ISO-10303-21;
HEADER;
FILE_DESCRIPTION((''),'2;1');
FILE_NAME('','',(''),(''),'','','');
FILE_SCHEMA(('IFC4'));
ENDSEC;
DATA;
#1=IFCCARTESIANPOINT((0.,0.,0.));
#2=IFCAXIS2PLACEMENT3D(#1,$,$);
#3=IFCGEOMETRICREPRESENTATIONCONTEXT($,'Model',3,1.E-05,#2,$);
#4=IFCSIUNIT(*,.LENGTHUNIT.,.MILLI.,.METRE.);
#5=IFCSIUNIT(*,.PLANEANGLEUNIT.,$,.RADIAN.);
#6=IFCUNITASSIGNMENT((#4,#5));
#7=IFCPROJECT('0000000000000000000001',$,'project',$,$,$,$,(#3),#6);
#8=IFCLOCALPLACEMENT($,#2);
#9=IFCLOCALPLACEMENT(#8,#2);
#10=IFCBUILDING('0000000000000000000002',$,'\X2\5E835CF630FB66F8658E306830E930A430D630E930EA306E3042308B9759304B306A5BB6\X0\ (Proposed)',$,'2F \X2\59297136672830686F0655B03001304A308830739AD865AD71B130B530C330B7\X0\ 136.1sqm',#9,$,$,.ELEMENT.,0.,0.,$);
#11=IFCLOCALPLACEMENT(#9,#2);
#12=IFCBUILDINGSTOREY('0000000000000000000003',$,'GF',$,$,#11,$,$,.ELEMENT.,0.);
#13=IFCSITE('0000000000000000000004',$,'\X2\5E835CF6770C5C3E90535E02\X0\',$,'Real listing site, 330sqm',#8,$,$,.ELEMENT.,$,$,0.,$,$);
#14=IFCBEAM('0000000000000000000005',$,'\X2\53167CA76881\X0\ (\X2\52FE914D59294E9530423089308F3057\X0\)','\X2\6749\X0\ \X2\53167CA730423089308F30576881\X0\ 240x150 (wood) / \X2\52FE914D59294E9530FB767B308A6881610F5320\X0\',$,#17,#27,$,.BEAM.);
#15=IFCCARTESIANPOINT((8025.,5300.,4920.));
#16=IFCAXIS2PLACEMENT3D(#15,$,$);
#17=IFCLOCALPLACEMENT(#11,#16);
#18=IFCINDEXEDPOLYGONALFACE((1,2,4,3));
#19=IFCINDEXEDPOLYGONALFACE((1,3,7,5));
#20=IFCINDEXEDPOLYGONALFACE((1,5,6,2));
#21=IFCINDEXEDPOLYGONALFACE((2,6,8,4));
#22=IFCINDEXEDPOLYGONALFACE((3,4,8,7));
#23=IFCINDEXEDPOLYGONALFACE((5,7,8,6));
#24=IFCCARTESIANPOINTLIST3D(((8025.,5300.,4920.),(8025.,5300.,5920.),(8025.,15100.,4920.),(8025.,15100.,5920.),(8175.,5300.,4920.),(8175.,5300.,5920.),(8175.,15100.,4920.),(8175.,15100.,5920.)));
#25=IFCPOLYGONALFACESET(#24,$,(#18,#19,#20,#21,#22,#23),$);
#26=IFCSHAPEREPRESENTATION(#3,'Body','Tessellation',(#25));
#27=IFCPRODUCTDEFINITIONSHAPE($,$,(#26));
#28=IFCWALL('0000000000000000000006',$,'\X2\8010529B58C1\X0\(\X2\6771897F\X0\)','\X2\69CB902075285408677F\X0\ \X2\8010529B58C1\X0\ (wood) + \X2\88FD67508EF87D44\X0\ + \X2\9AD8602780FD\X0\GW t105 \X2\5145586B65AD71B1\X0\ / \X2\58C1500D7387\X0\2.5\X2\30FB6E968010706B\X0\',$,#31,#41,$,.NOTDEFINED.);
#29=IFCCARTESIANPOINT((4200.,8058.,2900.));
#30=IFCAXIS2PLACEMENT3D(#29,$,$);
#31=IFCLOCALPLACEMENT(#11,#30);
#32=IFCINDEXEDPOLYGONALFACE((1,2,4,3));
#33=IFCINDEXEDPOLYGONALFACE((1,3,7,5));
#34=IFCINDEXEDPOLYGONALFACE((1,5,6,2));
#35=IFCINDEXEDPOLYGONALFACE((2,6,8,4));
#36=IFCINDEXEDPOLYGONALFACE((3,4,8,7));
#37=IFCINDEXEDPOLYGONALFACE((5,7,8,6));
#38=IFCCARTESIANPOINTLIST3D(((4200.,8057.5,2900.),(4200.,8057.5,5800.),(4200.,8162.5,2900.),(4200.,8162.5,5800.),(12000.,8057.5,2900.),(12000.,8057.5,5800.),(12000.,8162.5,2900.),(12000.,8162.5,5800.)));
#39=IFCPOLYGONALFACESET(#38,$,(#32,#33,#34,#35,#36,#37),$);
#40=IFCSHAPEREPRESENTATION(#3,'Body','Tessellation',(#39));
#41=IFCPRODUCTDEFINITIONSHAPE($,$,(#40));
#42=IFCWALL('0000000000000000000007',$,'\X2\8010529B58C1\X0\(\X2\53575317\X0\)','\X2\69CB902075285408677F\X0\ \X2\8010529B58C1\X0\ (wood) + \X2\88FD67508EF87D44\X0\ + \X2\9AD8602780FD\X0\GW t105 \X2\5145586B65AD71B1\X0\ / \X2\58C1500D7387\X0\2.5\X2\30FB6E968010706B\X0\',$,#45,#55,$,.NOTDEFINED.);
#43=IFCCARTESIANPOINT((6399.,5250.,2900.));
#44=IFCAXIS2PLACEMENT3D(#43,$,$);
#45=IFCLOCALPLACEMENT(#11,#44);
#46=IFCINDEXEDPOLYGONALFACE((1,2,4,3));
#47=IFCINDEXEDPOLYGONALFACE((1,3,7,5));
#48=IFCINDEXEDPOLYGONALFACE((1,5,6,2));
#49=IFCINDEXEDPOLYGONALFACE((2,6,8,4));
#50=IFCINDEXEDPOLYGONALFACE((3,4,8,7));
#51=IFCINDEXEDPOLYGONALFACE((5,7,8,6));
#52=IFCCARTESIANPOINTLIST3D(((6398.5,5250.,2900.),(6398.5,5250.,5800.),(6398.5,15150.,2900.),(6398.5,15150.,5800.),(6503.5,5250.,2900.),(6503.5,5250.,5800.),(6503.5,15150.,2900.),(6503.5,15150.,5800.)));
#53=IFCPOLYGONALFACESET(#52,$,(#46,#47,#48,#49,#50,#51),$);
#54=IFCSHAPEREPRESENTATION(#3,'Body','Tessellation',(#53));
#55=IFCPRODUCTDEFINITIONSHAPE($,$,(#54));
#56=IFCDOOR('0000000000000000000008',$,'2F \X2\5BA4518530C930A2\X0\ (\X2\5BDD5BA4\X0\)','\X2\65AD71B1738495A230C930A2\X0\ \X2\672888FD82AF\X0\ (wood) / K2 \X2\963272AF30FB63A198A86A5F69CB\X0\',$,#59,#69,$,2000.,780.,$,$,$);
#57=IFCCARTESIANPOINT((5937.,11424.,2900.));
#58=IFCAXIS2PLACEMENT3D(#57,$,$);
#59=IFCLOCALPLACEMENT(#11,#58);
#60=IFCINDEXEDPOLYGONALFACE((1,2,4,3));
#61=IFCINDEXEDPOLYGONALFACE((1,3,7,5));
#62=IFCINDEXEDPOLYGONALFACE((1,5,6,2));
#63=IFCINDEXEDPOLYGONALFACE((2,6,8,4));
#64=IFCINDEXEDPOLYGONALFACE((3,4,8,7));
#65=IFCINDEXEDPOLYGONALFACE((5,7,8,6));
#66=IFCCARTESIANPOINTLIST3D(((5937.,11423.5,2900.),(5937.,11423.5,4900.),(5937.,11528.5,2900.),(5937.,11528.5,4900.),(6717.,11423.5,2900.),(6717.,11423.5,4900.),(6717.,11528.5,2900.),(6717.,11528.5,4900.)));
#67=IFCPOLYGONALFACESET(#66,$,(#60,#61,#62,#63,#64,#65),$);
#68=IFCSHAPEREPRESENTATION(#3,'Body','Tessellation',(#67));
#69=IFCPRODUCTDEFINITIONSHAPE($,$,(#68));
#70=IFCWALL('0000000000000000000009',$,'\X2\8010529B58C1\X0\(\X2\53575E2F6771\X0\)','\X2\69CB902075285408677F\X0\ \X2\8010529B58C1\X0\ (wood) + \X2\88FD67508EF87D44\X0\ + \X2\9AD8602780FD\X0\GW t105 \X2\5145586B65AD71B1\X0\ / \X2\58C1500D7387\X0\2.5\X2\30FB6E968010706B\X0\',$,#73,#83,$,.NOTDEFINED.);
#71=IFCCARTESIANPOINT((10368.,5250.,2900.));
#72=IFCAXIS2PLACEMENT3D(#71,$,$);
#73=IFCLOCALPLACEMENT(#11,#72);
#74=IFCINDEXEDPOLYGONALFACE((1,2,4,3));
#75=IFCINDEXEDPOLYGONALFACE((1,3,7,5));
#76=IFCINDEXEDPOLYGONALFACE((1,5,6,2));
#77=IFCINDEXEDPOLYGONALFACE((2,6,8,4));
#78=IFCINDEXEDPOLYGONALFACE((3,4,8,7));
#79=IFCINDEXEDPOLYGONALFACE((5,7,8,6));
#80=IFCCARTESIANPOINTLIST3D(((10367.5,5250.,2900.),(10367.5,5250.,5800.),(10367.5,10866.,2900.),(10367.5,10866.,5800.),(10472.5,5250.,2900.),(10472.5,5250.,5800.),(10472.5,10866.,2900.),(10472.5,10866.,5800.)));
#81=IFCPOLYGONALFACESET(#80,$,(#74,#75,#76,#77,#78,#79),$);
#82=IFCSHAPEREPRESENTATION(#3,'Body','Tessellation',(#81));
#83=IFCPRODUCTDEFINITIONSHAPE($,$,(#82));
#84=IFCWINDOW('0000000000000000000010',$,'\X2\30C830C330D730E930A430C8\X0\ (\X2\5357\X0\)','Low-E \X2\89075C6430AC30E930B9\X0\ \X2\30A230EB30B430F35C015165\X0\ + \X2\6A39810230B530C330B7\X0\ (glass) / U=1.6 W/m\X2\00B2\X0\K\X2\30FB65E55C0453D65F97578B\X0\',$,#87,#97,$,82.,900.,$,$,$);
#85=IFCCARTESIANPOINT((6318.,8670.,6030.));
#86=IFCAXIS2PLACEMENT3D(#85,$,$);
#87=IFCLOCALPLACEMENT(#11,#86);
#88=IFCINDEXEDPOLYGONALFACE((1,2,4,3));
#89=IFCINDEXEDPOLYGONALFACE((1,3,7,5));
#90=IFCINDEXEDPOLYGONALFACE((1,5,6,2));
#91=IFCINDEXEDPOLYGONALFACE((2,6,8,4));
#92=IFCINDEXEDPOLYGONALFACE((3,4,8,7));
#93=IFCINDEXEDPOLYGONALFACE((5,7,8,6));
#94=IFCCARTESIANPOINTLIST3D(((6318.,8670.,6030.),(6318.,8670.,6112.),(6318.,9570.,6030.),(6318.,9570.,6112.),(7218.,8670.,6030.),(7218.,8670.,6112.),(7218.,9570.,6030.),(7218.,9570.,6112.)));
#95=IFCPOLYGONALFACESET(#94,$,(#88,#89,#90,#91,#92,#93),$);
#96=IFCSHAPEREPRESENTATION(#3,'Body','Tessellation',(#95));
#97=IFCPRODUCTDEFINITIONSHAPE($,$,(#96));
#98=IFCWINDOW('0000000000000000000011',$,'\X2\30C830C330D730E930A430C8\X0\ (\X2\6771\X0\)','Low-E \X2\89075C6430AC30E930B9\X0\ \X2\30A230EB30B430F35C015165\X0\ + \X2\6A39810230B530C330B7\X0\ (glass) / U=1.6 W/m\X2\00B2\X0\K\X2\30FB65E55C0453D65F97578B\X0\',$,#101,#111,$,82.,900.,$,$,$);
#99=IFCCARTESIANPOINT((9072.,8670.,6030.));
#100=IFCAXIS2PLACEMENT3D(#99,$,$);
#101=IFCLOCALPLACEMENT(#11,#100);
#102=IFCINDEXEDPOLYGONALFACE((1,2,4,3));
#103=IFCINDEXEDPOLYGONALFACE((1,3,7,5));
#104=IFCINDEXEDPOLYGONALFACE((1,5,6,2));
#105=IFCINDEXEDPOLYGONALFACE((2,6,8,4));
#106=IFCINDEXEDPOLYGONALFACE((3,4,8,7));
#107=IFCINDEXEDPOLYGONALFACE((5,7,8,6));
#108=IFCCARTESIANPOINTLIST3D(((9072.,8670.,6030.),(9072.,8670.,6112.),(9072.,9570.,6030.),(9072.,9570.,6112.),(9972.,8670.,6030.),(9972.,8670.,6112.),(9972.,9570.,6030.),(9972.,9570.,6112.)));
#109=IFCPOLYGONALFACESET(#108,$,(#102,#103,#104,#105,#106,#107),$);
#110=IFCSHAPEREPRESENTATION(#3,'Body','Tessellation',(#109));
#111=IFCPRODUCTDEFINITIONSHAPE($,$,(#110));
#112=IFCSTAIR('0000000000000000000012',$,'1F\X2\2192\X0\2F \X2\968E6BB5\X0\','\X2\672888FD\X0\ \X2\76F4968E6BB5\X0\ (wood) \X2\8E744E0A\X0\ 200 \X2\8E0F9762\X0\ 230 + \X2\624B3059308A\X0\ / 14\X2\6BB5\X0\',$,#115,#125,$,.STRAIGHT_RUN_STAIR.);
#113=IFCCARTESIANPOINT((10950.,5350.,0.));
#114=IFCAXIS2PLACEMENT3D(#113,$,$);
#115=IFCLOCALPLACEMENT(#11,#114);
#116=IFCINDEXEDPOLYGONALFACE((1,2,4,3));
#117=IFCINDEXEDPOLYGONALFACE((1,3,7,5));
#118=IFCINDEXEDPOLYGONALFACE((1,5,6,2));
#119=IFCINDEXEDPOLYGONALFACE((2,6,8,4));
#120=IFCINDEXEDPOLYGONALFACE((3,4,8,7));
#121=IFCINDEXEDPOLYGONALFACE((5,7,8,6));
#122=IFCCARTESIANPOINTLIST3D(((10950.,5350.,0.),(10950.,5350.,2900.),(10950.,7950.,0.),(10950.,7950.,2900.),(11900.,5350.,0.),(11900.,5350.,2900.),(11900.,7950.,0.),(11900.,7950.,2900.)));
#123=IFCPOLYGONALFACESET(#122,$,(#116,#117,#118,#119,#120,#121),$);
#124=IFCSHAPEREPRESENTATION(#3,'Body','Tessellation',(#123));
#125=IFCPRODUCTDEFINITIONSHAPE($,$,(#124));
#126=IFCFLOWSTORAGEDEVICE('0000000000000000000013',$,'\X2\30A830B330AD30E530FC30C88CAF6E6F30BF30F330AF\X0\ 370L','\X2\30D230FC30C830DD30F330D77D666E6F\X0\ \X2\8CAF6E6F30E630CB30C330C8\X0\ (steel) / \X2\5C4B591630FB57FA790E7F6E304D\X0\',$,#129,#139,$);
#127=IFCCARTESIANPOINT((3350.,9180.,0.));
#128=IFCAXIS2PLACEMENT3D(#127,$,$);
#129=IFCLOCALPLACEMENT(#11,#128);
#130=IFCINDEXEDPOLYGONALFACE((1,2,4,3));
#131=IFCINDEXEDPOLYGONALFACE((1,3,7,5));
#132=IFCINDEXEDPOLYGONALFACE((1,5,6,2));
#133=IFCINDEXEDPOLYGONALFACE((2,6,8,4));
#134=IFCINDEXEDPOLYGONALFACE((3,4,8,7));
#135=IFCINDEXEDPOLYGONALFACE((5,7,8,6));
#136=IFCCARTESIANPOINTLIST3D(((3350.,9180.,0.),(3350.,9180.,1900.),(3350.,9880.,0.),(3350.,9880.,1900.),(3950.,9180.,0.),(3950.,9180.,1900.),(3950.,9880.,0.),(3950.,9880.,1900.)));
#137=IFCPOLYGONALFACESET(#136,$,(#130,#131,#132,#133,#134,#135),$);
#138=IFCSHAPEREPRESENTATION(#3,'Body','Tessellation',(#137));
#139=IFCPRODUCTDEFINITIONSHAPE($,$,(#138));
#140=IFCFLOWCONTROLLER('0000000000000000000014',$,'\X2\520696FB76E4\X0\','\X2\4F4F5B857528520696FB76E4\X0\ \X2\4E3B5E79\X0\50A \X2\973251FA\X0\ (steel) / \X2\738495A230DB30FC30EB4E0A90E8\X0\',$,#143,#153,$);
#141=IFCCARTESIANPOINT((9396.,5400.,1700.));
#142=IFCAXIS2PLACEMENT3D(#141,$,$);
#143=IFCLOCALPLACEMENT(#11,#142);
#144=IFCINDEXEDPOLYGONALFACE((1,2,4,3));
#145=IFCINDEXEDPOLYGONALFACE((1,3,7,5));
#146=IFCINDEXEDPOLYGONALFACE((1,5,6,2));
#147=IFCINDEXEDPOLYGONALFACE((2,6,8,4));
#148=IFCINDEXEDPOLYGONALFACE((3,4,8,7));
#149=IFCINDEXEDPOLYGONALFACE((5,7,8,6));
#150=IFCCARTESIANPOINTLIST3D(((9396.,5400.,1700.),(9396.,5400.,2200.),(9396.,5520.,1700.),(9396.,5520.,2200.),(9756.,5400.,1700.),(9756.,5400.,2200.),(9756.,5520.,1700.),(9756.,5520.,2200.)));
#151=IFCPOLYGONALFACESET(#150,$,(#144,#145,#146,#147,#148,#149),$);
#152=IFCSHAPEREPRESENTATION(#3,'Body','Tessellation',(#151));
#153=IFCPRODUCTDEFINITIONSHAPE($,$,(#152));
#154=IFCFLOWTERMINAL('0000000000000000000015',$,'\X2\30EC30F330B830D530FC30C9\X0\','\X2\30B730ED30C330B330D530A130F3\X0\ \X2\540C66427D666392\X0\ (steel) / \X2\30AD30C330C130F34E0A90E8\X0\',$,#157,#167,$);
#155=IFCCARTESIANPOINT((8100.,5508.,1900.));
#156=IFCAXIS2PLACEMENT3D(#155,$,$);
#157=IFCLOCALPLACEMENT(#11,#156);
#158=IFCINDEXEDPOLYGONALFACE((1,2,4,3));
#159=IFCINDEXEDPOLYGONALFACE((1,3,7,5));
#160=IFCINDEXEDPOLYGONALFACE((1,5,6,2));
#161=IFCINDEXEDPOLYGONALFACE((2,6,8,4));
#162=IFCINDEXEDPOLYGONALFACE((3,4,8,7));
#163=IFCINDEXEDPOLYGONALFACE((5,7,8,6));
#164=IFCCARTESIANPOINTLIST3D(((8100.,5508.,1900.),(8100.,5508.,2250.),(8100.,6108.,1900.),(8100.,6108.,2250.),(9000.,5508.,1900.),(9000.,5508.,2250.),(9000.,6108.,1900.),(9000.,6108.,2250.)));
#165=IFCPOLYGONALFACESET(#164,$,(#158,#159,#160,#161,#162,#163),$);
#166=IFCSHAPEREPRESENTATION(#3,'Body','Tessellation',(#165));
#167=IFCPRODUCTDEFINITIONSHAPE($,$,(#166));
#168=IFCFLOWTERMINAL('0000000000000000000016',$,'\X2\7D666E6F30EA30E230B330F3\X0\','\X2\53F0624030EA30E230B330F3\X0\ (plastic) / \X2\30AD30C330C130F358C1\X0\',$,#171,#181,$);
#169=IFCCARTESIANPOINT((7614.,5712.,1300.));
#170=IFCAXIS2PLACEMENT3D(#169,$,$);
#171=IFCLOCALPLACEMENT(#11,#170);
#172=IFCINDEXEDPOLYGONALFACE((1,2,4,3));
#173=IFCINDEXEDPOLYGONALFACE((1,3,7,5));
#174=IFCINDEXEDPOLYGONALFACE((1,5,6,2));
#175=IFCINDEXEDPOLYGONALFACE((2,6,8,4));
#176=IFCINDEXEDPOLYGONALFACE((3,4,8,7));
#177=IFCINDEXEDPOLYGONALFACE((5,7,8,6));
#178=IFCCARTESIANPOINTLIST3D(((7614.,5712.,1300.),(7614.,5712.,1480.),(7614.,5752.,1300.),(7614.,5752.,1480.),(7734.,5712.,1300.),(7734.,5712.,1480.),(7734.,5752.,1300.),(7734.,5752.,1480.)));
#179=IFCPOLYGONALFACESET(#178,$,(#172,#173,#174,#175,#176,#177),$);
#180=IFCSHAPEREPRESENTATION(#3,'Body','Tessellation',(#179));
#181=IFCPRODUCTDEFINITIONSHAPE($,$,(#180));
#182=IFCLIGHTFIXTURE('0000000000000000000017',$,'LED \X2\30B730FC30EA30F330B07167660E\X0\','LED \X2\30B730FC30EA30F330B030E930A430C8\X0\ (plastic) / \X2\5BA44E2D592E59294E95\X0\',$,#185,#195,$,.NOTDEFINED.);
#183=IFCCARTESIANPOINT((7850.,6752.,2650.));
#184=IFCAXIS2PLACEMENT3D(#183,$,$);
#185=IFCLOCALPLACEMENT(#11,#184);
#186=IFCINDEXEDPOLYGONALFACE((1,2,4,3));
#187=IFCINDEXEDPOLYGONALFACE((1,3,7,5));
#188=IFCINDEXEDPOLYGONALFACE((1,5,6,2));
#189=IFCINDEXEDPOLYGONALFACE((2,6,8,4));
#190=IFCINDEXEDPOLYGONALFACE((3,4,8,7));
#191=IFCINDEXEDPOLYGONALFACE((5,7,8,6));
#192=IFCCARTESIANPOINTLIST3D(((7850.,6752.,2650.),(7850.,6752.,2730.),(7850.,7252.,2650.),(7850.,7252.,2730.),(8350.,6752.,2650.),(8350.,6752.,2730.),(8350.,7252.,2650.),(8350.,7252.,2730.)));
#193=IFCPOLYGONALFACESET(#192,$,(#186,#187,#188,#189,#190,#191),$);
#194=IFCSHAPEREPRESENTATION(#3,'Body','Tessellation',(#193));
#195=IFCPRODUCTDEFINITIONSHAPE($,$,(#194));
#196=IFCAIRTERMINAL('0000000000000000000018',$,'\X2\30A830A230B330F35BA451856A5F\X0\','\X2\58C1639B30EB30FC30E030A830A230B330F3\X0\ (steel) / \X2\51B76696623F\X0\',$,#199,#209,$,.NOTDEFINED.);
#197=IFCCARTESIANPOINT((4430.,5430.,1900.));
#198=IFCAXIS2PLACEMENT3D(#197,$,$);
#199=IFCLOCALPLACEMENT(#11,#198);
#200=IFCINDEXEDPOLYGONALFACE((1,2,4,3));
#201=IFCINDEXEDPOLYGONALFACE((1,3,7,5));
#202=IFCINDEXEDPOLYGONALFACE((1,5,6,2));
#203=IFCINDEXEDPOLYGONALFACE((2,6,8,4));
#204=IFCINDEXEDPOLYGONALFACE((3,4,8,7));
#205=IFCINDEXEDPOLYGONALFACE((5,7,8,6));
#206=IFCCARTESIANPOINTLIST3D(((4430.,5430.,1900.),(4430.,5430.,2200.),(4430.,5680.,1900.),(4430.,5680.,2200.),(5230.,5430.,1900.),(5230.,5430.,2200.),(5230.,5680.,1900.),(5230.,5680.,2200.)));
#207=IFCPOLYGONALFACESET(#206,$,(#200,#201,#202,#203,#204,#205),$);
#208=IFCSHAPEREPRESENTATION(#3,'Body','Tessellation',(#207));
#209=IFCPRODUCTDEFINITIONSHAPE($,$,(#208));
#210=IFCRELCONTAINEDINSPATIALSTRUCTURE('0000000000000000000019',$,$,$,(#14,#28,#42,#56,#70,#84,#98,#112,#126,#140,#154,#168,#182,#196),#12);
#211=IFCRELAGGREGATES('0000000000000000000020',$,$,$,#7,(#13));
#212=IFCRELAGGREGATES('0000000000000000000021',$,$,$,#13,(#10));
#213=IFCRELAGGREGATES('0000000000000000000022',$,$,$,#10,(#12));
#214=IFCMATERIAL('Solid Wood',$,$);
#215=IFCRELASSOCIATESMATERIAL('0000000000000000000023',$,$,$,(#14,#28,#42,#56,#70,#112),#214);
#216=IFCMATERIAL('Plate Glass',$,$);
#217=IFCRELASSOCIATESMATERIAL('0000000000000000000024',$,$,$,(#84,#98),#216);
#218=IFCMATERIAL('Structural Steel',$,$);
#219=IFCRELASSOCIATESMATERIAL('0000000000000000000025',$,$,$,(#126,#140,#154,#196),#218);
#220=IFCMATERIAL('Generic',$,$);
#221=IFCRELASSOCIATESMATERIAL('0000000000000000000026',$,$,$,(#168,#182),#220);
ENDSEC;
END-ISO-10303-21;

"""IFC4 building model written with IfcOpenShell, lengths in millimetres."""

from ifc_helpers import new_model, si_unit, frame, frame_2d, origin, place, context, project, spatial, rectangle, extrude, material, element, fill, save


model = new_model("IFC4")

# Units and contexts
model_context = context("Model", 3, precision=1e-05, world=origin())
ifc_project = project(units=[si_unit("LENGTHUNIT", "METRE", prefix="MILLI"), si_unit("PLANEANGLEUNIT", "RADIAN")], contexts=[model_context])

# Site, building, storey
site_placement = place(None, origin())
site = spatial("IfcSite", under=ifc_project, at=site_placement, Name="広島県尾道市", ObjectType="Real listing site, 330sqm", CompositionType="ELEMENT", RefElevation=0.0)
building_placement = place(site_placement, origin())
building = spatial("IfcBuilding", under=site, at=building_placement, Name="広島・書斎とライブラリのある静かな家 (Proposed)", ObjectType="2F 天然木と漆喰、および高断熱サッシ 136.1sqm", CompositionType="ELEMENT", ElevationOfRefHeight=0.0, ElevationOfTerrain=0.0)
storey_placement = place(building_placement, origin())
storey = spatial("IfcBuildingStorey", under=building, at=storey_placement, Name="GF", CompositionType="ELEMENT", Elevation=0.0)

# Shared definitions
ifc_material_1 = material(Name="Solid Wood")

# Beam
beam_placement = place(storey_placement, frame((8025.0, 5300.0, 4920.0)))
element("IfcBeam", 1, at=beam_placement, inside=storey, material=ifc_material_1, Name="化粧梁 (勾配天井あらわし)", Description="杉 化粧あらわし梁 240x150 (wood) / 勾配天井・登り梁意匠", PredefinedType="BEAM", context=model_context, shape_type="SweptSolid", body=[
    extrude(rectangle(XDim=150.0, YDim=9800.0, at=frame_2d((75.0, 4900.0))), frame((8025.0, 5300.0, 4920.0)), (0.0, 0.0, 1.0), 1000.0),
])

# Wall
wall_1_placement = place(storey_placement, frame((4200.0, 8058.0, 2900.0)))
element("IfcWall", 2, at=wall_1_placement, inside=storey, material=ifc_material_1, Name="耐力壁(東西)", Description="構造用合板 耐力壁 (wood) + 製材軸組 + 高性能GW t105 充填断熱 / 壁倍率2.5・準耐火", PredefinedType="NOTDEFINED", context=model_context, shape_type="SweptSolid", body=[
    extrude(rectangle(XDim=7800.0, YDim=105.0, at=frame_2d((3900.0, 52.0))), frame((4200.0, 8058.0, 2900.0)), (0.0, 0.0, 1.0), 2900.0),
])

# Wall, opening, door
wall_2_placement = place(storey_placement, frame((6399.0, 5250.0, 2900.0)))
wall_2 = element("IfcWall", 3, at=wall_2_placement, inside=storey, material=ifc_material_1, Name="耐力壁(南北)", Description="構造用合板 耐力壁 (wood) + 製材軸組 + 高性能GW t105 充填断熱 / 壁倍率2.5・準耐火", PredefinedType="NOTDEFINED", context=model_context, shape_type="SweptSolid", body=[
    extrude(rectangle(XDim=105.0, YDim=9900.0, at=frame_2d((52.0, 4950.0))), frame((6399.0, 5250.0, 2900.0)), (0.0, 0.0, 1.0), 2900.0),
])
opening_placement = place(storey_placement, frame((5937.0, 11424.0, 2900.0)))
opening = element("IfcOpeningElement", 4, at=opening_placement, cuts=wall_2, PredefinedType="NOTDEFINED", context=model_context, shape_type="SweptSolid", body=[
    extrude(rectangle(XDim=780.0, YDim=105.0, at=frame_2d((390.0, 52.0))), frame((5937.0, 11424.0, 2900.0)), (0.0, 0.0, 1.0), 2000.0),
])
door_placement = place(storey_placement, frame((5937.0, 11424.0, 2900.0)))
door = element("IfcDoor", 5, at=door_placement, inside=storey, material=ifc_material_1, Name="2F 室内ドア (寝室)", Description="断熱玄関ドア 木製芯 (wood) / K2 防犯・採風機構", OverallHeight=2000.0, OverallWidth=780.0, context=model_context, shape_type="SweptSolid", body=[
    extrude(rectangle(XDim=780.0, YDim=105.0, at=frame_2d((390.0, 52.0))), frame((5937.0, 11424.0, 2900.0)), (0.0, 0.0, 1.0), 2000.0),
])
fill(opening, door)

# Wall
wall_3_placement = place(storey_placement, frame((10368.0, 5250.0, 2900.0)))
element("IfcWall", 6, at=wall_3_placement, inside=storey, material=ifc_material_1, Name="耐力壁(南帯東)", Description="構造用合板 耐力壁 (wood) + 製材軸組 + 高性能GW t105 充填断熱 / 壁倍率2.5・準耐火", PredefinedType="NOTDEFINED", context=model_context, shape_type="SweptSolid", body=[
    extrude(rectangle(XDim=105.0, YDim=5616.0, at=frame_2d((52.0, 2808.0))), frame((10368.0, 5250.0, 2900.0)), (0.0, 0.0, 1.0), 2900.0),
])

# Windows
ifc_material_2 = material(Name="Plate Glass")
window_1_placement = place(storey_placement, frame((6318.0, 8670.0, 6030.0)))
element("IfcWindow", 7, at=window_1_placement, inside=storey, material=ifc_material_2, Name="トップライト (南)", Description="Low-E 複層ガラス アルゴン封入 + 樹脂サッシ (glass) / U=1.6 W/m²K・日射取得型", OverallHeight=82.0, OverallWidth=900.0, context=model_context, shape_type="SweptSolid", body=[
    extrude(rectangle(XDim=900.0, YDim=900.0, at=frame_2d((450.0, 450.0))), frame((6318.0, 8670.0, 6030.0)), (0.0, 0.0, 1.0), 82.0),
])
window_2_placement = place(storey_placement, frame((9072.0, 8670.0, 6030.0)))
element("IfcWindow", 8, at=window_2_placement, inside=storey, material=ifc_material_2, Name="トップライト (東)", Description="Low-E 複層ガラス アルゴン封入 + 樹脂サッシ (glass) / U=1.6 W/m²K・日射取得型", OverallHeight=82.0, OverallWidth=900.0, context=model_context, shape_type="SweptSolid", body=[
    extrude(rectangle(XDim=900.0, YDim=900.0, at=frame_2d((450.0, 450.0))), frame((9072.0, 8670.0, 6030.0)), (0.0, 0.0, 1.0), 82.0),
])

# Stair
stair_placement = place(storey_placement, frame((10950.0, 5350.0, 0.0)))
element("IfcStair", 9, at=stair_placement, inside=storey, material=ifc_material_1, Name="1F→2F 階段", Description="木製 直階段 (wood) 蹴上 200 踏面 230 + 手すり / 14段", PredefinedType="STRAIGHT_RUN_STAIR", context=model_context, shape_type="SweptSolid", body=[
    extrude(rectangle(XDim=950.0, YDim=2600.0, at=frame_2d((475.0, 1300.0))), frame((10950.0, 5350.0, 0.0)), (0.0, 0.0, 1.0), 2900.0),
])

# Flow storage device
ifc_material_3 = material(Name="Structural Steel")
flow_storage_device_placement = place(storey_placement, frame((3350.0, 9180.0, 0.0)))
element("IfcFlowStorageDevice", 10, at=flow_storage_device_placement, inside=storey, material=ifc_material_3, Name="エコキュート貯湯タンク 370L", Description="ヒートポンプ給湯 貯湯ユニット (steel) / 屋外・基礎置き", context=model_context, shape_type="SweptSolid", body=[
    extrude(rectangle(XDim=600.0, YDim=700.0, at=frame_2d((300.0, 350.0))), frame((3350.0, 9180.0, 0.0)), (0.0, 0.0, 1.0), 1900.0),
])

# Flow controller
flow_controller_placement = place(storey_placement, frame((9396.0, 5400.0, 1700.0)))
element("IfcFlowController", 11, at=flow_controller_placement, inside=storey, material=ifc_material_3, Name="分電盤", Description="住宅用分電盤 主幹50A 露出 (steel) / 玄関ホール上部", context=model_context, shape_type="SweptSolid", body=[
    extrude(rectangle(XDim=360.0, YDim=120.0, at=frame_2d((180.0, 60.0))), frame((9396.0, 5400.0, 1700.0)), (0.0, 0.0, 1.0), 500.0),
])

# Flow terminals
flow_terminal_1_placement = place(storey_placement, frame((8100.0, 5508.0, 1900.0)))
element("IfcFlowTerminal", 12, at=flow_terminal_1_placement, inside=storey, material=ifc_material_3, Name="レンジフード", Description="シロッコファン 同時給排 (steel) / キッチン上部", context=model_context, shape_type="SweptSolid", body=[
    extrude(rectangle(XDim=900.0, YDim=600.0, at=frame_2d((450.0, 300.0))), frame((8100.0, 5508.0, 1900.0)), (0.0, 0.0, 1.0), 350.0),
])
ifc_material_4 = material(Name="Generic")
flow_terminal_2_placement = place(storey_placement, frame((7614.0, 5712.0, 1300.0)))
element("IfcFlowTerminal", 13, at=flow_terminal_2_placement, inside=storey, material=ifc_material_4, Name="給湯リモコン", Description="台所リモコン (plastic) / キッチン壁", context=model_context, shape_type="SweptSolid", body=[
    extrude(rectangle(XDim=120.0, YDim=40.0, at=frame_2d((60.0, 20.0))), frame((7614.0, 5712.0, 1300.0)), (0.0, 0.0, 1.0), 180.0),
])

# Light fixture
light_fixture_1_placement = place(storey_placement, frame((7850.0, 6752.0, 2650.0)))
element("IfcLightFixture", 14, at=light_fixture_1_placement, inside=storey, material=ifc_material_4, Name="LED シーリング照明", Description="LED シーリングライト (plastic) / 室中央天井", PredefinedType="NOTDEFINED", context=model_context, shape_type="SweptSolid", body=[
    extrude(rectangle(XDim=500.0, YDim=500.0, at=frame_2d((250.0, 250.0))), frame((7850.0, 6752.0, 2650.0)), (0.0, 0.0, 1.0), 80.0),
])

# Air terminal
air_terminal_1_placement = place(storey_placement, frame((4430.0, 5430.0, 1900.0)))
element("IfcAirTerminal", 15, at=air_terminal_1_placement, inside=storey, material=ifc_material_3, Name="エアコン室内機", Description="壁掛ルームエアコン (steel) / 冷暖房", PredefinedType="NOTDEFINED", context=model_context, shape_type="SweptSolid", body=[
    extrude(rectangle(XDim=800.0, YDim=250.0, at=frame_2d((400.0, 125.0))), frame((4430.0, 5430.0, 1900.0)), (0.0, 0.0, 1.0), 300.0),
])

save(model, "model.ifc")
